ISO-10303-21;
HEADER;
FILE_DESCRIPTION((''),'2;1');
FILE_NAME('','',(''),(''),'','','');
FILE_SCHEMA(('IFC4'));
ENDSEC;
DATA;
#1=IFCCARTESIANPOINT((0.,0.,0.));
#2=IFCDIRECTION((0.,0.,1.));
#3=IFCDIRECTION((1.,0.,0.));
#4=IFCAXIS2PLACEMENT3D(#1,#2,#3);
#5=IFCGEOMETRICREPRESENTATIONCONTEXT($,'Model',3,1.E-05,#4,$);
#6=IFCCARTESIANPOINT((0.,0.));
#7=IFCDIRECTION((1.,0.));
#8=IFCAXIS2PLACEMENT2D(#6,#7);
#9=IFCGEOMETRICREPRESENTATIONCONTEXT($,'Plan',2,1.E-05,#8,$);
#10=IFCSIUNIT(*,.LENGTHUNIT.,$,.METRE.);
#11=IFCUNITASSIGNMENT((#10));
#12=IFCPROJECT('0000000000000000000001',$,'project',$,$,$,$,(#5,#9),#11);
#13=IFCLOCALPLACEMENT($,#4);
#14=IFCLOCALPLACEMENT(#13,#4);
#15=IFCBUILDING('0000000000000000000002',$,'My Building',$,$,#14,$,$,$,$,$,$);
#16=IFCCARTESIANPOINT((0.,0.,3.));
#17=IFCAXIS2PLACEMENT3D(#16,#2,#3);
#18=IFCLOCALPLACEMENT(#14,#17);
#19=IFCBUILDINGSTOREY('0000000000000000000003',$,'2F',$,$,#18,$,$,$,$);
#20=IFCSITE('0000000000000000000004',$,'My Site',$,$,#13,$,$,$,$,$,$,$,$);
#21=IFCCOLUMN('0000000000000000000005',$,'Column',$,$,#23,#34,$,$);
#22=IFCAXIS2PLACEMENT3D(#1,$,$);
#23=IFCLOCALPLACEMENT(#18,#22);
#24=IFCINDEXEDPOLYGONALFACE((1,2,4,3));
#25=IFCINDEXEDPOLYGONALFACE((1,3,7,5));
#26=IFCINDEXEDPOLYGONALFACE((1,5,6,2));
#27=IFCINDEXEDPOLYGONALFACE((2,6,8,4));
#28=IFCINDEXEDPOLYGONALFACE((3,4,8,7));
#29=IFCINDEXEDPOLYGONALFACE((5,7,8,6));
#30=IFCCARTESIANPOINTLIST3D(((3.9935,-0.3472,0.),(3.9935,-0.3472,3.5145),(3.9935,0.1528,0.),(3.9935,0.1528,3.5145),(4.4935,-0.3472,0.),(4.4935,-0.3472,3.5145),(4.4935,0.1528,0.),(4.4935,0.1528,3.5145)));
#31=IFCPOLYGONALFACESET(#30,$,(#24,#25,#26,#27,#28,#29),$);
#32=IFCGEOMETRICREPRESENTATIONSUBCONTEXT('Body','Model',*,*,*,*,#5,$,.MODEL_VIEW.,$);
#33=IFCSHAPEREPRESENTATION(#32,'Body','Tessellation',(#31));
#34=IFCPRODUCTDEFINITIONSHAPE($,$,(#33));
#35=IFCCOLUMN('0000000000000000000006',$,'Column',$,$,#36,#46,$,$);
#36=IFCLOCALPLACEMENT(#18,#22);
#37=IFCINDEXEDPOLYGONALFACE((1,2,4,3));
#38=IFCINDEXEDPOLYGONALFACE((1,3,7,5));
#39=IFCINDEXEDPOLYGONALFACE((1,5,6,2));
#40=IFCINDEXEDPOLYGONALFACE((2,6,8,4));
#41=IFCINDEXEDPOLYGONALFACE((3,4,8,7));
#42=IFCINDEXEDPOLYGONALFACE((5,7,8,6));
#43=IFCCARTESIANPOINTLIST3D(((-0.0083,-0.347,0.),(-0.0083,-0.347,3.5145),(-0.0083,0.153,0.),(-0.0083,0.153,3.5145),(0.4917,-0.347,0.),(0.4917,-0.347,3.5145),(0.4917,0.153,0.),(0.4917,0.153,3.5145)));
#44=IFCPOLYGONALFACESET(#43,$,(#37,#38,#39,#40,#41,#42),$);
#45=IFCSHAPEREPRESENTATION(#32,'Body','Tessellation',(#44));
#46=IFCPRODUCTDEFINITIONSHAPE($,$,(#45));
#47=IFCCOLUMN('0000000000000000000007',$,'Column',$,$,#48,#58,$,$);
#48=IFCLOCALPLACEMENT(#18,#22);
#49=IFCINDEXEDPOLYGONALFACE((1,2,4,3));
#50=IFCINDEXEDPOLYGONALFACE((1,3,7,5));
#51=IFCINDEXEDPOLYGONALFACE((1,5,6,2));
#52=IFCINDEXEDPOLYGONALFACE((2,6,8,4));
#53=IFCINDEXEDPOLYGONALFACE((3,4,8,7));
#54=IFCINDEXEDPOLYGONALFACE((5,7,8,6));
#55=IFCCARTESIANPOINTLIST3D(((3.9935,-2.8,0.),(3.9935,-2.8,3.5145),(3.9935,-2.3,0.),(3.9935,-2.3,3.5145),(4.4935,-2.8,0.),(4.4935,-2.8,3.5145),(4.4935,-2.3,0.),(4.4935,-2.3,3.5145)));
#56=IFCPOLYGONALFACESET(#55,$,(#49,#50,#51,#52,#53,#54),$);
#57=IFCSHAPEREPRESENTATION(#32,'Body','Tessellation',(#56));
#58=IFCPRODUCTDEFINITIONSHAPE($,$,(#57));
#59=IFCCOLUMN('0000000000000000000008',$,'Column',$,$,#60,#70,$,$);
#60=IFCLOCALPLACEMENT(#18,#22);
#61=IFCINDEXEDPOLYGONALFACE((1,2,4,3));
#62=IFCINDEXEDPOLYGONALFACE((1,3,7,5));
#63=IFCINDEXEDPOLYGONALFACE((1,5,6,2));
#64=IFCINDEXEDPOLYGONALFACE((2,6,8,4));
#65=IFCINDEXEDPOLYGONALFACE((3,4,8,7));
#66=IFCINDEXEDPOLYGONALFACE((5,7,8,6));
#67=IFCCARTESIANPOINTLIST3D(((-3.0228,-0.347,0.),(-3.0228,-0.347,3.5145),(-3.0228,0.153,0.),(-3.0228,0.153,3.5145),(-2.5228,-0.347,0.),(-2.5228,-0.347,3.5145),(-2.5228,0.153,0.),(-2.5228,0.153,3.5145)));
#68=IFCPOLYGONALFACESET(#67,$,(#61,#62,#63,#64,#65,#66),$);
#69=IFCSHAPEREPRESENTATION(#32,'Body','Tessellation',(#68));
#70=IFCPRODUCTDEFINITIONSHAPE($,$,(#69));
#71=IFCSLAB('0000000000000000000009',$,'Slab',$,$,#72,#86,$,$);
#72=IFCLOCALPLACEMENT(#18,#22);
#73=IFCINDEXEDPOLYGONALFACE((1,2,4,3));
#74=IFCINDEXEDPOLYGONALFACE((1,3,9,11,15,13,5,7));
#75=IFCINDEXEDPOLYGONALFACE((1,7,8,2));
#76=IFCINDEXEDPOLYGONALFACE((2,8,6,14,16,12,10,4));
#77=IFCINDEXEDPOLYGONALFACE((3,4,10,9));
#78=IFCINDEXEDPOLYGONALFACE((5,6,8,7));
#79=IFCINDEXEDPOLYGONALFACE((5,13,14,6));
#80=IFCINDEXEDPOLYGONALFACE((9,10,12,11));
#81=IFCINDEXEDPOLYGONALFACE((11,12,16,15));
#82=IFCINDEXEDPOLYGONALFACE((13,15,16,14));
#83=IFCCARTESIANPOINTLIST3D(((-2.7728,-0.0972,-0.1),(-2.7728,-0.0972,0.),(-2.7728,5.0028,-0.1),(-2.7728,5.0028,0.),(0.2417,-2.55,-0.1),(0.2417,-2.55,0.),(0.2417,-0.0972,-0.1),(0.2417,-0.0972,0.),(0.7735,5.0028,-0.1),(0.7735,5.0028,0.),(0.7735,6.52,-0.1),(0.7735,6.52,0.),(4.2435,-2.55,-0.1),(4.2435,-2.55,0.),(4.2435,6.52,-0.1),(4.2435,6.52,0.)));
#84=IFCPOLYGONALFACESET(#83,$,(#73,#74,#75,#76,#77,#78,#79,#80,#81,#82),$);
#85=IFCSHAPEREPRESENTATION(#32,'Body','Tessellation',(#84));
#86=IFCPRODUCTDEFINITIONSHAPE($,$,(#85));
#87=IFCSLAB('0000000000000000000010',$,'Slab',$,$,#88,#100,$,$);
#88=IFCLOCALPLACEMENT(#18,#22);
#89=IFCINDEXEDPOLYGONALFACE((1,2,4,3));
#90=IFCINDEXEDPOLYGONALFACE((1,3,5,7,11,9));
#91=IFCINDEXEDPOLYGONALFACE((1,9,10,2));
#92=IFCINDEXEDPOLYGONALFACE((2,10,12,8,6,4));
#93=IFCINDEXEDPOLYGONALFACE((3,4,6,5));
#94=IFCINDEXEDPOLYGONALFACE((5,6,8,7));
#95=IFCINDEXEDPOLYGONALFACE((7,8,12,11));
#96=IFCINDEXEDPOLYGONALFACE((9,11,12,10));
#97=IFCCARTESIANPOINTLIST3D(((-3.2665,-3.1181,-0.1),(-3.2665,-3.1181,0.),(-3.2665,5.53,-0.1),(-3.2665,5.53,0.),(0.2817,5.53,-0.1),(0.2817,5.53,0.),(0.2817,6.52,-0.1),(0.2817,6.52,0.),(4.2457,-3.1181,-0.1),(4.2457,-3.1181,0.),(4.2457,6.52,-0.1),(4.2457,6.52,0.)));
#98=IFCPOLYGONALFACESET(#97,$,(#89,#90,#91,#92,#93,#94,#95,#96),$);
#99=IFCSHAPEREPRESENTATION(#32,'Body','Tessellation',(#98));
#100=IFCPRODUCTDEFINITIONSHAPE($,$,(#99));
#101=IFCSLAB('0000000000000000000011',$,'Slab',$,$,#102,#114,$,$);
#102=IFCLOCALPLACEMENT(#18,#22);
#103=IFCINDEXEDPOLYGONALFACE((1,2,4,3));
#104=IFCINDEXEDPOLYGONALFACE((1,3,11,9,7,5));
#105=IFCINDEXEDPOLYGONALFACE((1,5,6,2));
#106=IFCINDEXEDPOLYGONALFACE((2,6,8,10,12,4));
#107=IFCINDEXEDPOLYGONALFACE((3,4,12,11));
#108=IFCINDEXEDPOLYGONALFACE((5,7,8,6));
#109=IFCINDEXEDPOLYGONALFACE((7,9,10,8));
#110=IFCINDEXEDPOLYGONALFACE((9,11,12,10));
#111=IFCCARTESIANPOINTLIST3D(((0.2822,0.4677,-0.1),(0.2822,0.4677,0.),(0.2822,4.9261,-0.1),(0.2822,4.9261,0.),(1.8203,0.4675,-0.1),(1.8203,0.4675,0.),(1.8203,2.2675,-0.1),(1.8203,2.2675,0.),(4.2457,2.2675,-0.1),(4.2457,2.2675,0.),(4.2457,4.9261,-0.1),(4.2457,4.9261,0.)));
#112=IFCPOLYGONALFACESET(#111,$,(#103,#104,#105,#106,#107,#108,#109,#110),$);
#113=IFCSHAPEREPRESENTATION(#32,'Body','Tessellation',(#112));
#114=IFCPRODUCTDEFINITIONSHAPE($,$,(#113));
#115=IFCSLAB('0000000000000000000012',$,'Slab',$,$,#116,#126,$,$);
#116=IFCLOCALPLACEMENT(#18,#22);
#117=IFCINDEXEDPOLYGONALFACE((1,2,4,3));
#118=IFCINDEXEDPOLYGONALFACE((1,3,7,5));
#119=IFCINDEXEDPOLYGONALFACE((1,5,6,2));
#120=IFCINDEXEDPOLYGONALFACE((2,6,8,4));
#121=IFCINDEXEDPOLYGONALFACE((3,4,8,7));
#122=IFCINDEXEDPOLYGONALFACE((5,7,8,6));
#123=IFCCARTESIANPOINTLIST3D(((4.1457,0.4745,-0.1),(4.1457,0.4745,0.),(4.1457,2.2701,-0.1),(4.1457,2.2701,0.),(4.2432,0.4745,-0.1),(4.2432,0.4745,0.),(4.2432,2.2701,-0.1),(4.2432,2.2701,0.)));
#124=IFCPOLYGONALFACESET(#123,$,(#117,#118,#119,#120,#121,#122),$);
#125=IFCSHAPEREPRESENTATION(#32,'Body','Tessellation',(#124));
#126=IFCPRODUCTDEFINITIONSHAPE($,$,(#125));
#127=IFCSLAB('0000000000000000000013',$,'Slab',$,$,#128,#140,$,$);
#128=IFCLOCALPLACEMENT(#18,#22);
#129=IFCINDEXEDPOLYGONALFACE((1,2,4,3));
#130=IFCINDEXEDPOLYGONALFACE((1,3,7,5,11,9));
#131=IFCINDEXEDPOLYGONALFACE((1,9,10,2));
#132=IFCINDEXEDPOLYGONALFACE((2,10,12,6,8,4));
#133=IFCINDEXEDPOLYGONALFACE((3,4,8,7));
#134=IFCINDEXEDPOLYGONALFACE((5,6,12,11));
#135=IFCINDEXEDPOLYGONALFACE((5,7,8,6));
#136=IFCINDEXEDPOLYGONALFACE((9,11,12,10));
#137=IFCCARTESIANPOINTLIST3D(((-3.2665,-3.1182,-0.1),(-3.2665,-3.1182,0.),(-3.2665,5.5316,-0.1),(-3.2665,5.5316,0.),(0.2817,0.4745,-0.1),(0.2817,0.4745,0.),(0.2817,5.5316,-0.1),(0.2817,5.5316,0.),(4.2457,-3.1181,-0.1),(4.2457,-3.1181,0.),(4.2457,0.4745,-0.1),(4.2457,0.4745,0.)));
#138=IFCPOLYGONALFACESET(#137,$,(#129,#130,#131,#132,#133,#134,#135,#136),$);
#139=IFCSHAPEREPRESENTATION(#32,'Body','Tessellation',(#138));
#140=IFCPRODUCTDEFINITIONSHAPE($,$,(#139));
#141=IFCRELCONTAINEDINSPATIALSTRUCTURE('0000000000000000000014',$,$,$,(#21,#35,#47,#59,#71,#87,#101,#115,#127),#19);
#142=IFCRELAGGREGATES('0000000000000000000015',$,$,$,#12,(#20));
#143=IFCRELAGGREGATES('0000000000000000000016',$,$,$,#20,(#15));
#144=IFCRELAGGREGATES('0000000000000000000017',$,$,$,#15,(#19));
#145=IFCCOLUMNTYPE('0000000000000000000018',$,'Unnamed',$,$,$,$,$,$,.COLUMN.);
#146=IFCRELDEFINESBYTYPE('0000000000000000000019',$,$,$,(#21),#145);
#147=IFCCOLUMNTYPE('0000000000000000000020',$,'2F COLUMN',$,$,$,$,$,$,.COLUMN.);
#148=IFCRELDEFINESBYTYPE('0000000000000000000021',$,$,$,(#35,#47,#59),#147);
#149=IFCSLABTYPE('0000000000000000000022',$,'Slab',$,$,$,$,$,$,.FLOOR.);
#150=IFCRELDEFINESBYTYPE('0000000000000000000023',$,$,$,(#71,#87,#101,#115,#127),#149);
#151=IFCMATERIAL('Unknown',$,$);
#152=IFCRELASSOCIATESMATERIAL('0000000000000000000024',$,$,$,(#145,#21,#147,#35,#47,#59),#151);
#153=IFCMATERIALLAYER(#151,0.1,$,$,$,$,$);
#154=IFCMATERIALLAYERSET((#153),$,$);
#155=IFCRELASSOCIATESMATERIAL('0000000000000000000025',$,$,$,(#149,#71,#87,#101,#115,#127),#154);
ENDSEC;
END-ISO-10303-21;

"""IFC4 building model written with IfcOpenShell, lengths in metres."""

from ifc_helpers import new_model, si_unit, frame, origin_with_axes, origin_2d_with_axis, place, context, subcontext, project, spatial, indexed_curve, rectangle, outline, extrude, material, layer, layer_set, layer_usage, material_profile, profile_set, profile_usage, type_object, element, save


model = new_model("IFC4")

# Units and contexts
model_context = context("Model", 3, precision=1e-05, world=origin_with_axes())
plan_context = context("Plan", 2, precision=1e-05, world=origin_2d_with_axis())
body_context_1 = subcontext(model_context, "Body", "Model", "MODEL_VIEW")
ifc_project = project(units=[si_unit("LENGTHUNIT", "METRE")], contexts=[model_context, plan_context])

# Site, building, storey
site_placement = place(None, origin_with_axes())
site = spatial("IfcSite", under=ifc_project, at=site_placement, Name="My Site")
building_placement = place(site_placement, origin_with_axes())
building = spatial("IfcBuilding", under=site, at=building_placement, Name="My Building")
storey_placement = place(building_placement, frame((0.0, 0.0, 3.0), z_axis=(0.0, 0.0, 1.0), x_axis=(1.0, 0.0, 0.0)))
storey = spatial("IfcBuildingStorey", under=building, at=storey_placement, Name="2F")

# Columns
ifc_material = material(Name="Unknown")
ifc_material_profile_1 = material_profile(ifc_material, rectangle(XDim=0.5, YDim=0.5))
ifc_profile_set_1 = profile_set([ifc_material_profile_1])
ifc_profile_usage_1 = profile_usage(ifc_profile_set_1, cardinal=7)
column_type_1 = type_object("IfcColumnType", Name="Unnamed", PredefinedType="COLUMN", material=ifc_profile_set_1)
column_1_placement = place(storey_placement, frame((4.4935, 0.1528, 0.0), z_axis=(0.0, 0.0, 1.0), x_axis=(1.0, 0.0, 0.0)))
element("IfcColumn", 1, at=column_1_placement, inside=storey, type_object=column_type_1, material=ifc_profile_usage_1, Name="Column", context=body_context_1, shape_type="SweptSolid", body=[
    extrude(rectangle(XDim=0.5, YDim=0.5), frame((-0.25, -0.25, 0.0), z_axis=(0.0, 0.0, 1.0), x_axis=(1.0, 0.0, 0.0)), (0.0, 0.0, 1.0), 3.5145),
])
ifc_material_profile_2 = material_profile(ifc_material, rectangle(XDim=0.5, YDim=0.5))
ifc_profile_set_2 = profile_set([ifc_material_profile_2])
ifc_profile_usage_2 = profile_usage(ifc_profile_set_2, cardinal=7)
column_type_2 = type_object("IfcColumnType", Name="2F COLUMN", PredefinedType="COLUMN", material=ifc_profile_set_2)
column_2_placement = place(storey_placement, frame((0.4917, 0.153, 0.0), z_axis=(0.0, 0.0, 1.0), x_axis=(1.0, 0.0, 0.0)))
element("IfcColumn", 2, at=column_2_placement, inside=storey, type_object=column_type_2, material=ifc_profile_usage_2, Name="Column", context=body_context_1, shape_type="SweptSolid", body=[
    extrude(rectangle(XDim=0.5, YDim=0.5), frame((-0.25, -0.25, 0.0), z_axis=(0.0, 0.0, 1.0), x_axis=(1.0, 0.0, 0.0)), (0.0, 0.0, 1.0), 3.5145),
])
ifc_profile_usage_3 = profile_usage(ifc_profile_set_2, cardinal=7)
column_3_placement = place(storey_placement, frame((4.4935, -2.3, 0.0), z_axis=(0.0, 0.0, 1.0), x_axis=(1.0, 0.0, 0.0)))
element("IfcColumn", 3, at=column_3_placement, inside=storey, type_object=column_type_2, material=ifc_profile_usage_3, Name="Column", context=body_context_1, shape_type="SweptSolid", body=[
    extrude(rectangle(XDim=0.5, YDim=0.5), frame((-0.25, -0.25, 0.0), z_axis=(0.0, 0.0, 1.0), x_axis=(1.0, 0.0, 0.0)), (0.0, 0.0, 1.0), 3.5145),
])
ifc_profile_usage_4 = profile_usage(ifc_profile_set_2, cardinal=7)
column_4_placement = place(storey_placement, frame((-2.5228, 0.153, 0.0), z_axis=(0.0, 0.0, 1.0), x_axis=(1.0, 0.0, 0.0)))
element("IfcColumn", 4, at=column_4_placement, inside=storey, type_object=column_type_2, material=ifc_profile_usage_4, Name="Column", context=body_context_1, shape_type="SweptSolid", body=[
    extrude(rectangle(XDim=0.5, YDim=0.5), frame((-0.25, -0.25, 0.0), z_axis=(0.0, 0.0, 1.0), x_axis=(1.0, 0.0, 0.0)), (0.0, 0.0, 1.0), 3.5145),
])

# Slabs
ifc_layer_1 = layer(ifc_material, 0.1)
ifc_layer_set_1 = layer_set([ifc_layer_1])
ifc_layer_usage_1 = layer_usage(ifc_layer_set_1, "AXIS3", "POSITIVE", -0.1)
slab_type = type_object("IfcSlabType", Name="Slab", PredefinedType="FLOOR", material=ifc_layer_set_1)
slab_1_placement = place(storey_placement, frame((4.2435, -2.55, 0.0), z_axis=(0.0, 0.0, 1.0), x_axis=(1.0, 0.0, 0.0)))
element("IfcSlab", 5, at=slab_1_placement, inside=storey, type_object=slab_type, material=ifc_layer_usage_1, Name="Slab", context=body_context_1, shape_type="SweptSolid", body=[
    extrude(outline(indexed_curve([(0.0, 0.0), (0.0, 9.07), (-3.47, 9.07), (-3.47, 7.5528), (-7.0163, 7.5528), (-7.0163, 2.4528), (-4.0018, 2.4528), (-4.0018, 0.0), (0.0, 0.0)])), frame((0.0, 0.0, -0.1), z_axis=(0.0, 0.0, 1.0), x_axis=(1.0, 0.0, 0.0)), (0.0, 0.0, 1.0), 0.1),
])
ifc_layer_usage_2 = layer_usage(ifc_layer_set_1, "AXIS3", "POSITIVE", -0.1)
slab_2_placement = place(storey_placement, frame((4.2457, -3.1181, 0.0), z_axis=(0.0, 0.0, 1.0), x_axis=(1.0, 0.0, 0.0)))
element("IfcSlab", 6, at=slab_2_placement, inside=storey, type_object=slab_type, material=ifc_layer_usage_2, Name="Slab", context=body_context_1, shape_type="SweptSolid", body=[
    extrude(outline(indexed_curve([(0.0, 0.0), (0.0, 9.6381), (-3.964, 9.6381), (-3.964, 8.6481), (-7.5122, 8.6481), (-7.5122, 0.0), (0.0, 0.0)])), frame((0.0, 0.0, -0.1), z_axis=(0.0, 0.0, 1.0), x_axis=(1.0, 0.0, 0.0)), (0.0, 0.0, 1.0), 0.1),
])
ifc_layer_usage_3 = layer_usage(ifc_layer_set_1, "AXIS3", "POSITIVE", -0.1)
slab_3_placement = place(storey_placement, frame((1.8203, 0.4675, 0.0), z_axis=(0.0, 0.0, 1.0), x_axis=(1.0, 0.0, 0.0)))
element("IfcSlab", 7, at=slab_3_placement, inside=storey, type_object=slab_type, material=ifc_layer_usage_3, Name="Slab", context=body_context_1, shape_type="SweptSolid", body=[
    extrude(outline(indexed_curve([(0.0, 0.0), (0.0, 1.8), (2.4254, 1.8), (2.4254, 4.4586), (-1.5381, 4.4586), (-1.5381, 0.0002), (0.0, 0.0)])), frame((0.0, 0.0, -0.1), z_axis=(0.0, 0.0, 1.0), x_axis=(1.0, 0.0, 0.0)), (0.0, 0.0, 1.0), 0.1),
])
ifc_layer_usage_4 = layer_usage(ifc_layer_set_1, "AXIS3", "POSITIVE", -0.1)
slab_4_placement = place(storey_placement, frame((4.1457, 0.4745, 0.0), z_axis=(0.0, 0.0, 1.0), x_axis=(1.0, 0.0, 0.0)))
element("IfcSlab", 8, at=slab_4_placement, inside=storey, type_object=slab_type, material=ifc_layer_usage_4, Name="Slab", context=body_context_1, shape_type="SweptSolid", body=[
    extrude(outline(indexed_curve([(0.0, 0.0), (0.0, 1.7956), (0.0975, 1.7956), (0.0975, -0.0001), (0.0, 0.0)])), frame((0.0, 0.0, -0.1), z_axis=(0.0, 0.0, 1.0), x_axis=(1.0, 0.0, 0.0)), (0.0, 0.0, 1.0), 0.1),
])
ifc_layer_usage_5 = layer_usage(ifc_layer_set_1, "AXIS3", "POSITIVE", -0.1)
slab_5_placement = place(storey_placement, frame((4.2457, -3.1181, 0.0), z_axis=(0.0, 0.0, 1.0), x_axis=(1.0, 0.0, 0.0)))
element("IfcSlab", 9, at=slab_5_placement, inside=storey, type_object=slab_type, material=ifc_layer_usage_5, Name="Slab", context=body_context_1, shape_type="SweptSolid", body=[
    extrude(outline(indexed_curve([(0.0, 0.0), (0.0, 3.5926), (-3.964, 3.5926), (-3.964, 8.6496), (-7.5122, 8.6496), (-7.5122, -0.0001), (0.0, 0.0)])), frame((0.0, 0.0, -0.1), z_axis=(0.0, 0.0, 1.0), x_axis=(1.0, 0.0, 0.0)), (0.0, 0.0, 1.0), 0.1),
])

save(model, "model.ifc")
